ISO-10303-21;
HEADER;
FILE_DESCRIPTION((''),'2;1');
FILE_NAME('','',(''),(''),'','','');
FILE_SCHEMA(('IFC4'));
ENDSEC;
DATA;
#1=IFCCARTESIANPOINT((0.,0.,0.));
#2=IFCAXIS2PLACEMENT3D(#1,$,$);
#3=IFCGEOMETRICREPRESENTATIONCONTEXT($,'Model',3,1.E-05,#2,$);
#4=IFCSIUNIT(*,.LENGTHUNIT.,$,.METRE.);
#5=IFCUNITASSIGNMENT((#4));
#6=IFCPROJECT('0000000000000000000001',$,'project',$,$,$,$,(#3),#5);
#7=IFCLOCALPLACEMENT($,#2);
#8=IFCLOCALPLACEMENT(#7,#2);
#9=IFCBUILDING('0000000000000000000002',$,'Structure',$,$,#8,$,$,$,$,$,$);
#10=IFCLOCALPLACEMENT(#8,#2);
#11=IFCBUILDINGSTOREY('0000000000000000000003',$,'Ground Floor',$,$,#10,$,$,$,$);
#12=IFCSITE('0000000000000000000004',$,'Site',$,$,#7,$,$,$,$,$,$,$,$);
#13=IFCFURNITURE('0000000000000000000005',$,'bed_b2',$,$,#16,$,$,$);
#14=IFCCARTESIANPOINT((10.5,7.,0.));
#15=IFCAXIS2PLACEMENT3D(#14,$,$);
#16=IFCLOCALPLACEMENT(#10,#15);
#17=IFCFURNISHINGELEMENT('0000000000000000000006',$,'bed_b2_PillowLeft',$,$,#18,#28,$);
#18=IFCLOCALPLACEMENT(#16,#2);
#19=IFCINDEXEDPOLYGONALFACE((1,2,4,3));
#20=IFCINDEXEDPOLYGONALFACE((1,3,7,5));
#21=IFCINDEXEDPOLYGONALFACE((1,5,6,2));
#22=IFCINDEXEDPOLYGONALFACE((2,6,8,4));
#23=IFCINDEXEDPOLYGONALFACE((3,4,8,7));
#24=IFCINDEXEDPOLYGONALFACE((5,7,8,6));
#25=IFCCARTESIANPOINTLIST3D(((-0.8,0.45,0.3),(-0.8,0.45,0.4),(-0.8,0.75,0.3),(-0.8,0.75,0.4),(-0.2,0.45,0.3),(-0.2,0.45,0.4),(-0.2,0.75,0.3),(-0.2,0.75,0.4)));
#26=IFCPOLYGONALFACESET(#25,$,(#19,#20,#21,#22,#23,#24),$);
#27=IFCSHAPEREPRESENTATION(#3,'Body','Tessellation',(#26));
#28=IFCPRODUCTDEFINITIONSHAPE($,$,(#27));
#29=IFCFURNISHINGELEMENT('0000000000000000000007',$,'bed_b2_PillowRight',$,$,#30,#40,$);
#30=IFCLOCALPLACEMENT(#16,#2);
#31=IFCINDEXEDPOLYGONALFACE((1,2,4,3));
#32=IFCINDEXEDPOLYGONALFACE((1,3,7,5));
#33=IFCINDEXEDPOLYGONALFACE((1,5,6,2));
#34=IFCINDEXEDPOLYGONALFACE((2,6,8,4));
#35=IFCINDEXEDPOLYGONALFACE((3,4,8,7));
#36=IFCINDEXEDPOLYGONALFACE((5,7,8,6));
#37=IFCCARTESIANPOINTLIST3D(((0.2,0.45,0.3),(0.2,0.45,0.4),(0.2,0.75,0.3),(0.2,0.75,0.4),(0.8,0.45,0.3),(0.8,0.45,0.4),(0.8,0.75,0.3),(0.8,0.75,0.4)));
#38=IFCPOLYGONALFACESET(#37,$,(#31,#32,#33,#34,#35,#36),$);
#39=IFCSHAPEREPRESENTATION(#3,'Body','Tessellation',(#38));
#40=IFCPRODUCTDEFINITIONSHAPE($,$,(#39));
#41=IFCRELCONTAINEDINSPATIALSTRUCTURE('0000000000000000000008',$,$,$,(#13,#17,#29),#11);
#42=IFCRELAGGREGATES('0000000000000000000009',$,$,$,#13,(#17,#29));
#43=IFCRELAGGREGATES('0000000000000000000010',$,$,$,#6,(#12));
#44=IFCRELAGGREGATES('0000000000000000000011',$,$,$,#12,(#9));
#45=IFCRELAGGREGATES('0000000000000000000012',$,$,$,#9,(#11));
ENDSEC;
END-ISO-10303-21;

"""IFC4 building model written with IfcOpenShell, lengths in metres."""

from ifc_helpers import new_model, si_unit, frame, origin, origin_2d, place, context, project, spatial, rectangle, extrude, element, aggregate, save


model = new_model("IFC4")

# Units and contexts
model_context = context("Model", 3, precision=1e-05, world=origin())
ifc_project = project(units=[si_unit("LENGTHUNIT", "METRE")], contexts=[model_context])

# Site, building, storey
site_placement = place(None, origin())
site = spatial("IfcSite", under=ifc_project, at=site_placement, Name="Site")
building_placement = place(site_placement, origin())
building = spatial("IfcBuilding", under=site, at=building_placement, Name="Structure")
storey_placement = place(building_placement, origin())
storey = spatial("IfcBuildingStorey", under=building, at=storey_placement, Name="Ground Floor")

# Furniture, furnishing elements
furniture_1_placement = place(storey_placement, frame((10.5, 7.0, 0.0)))
furniture_1 = element("IfcFurniture", 1, at=furniture_1_placement, inside=storey, Name="bed_b2")
furnishing_1_placement = place(furniture_1_placement, origin())
furnishing_1 = element("IfcFurnishingElement", 2, at=furnishing_1_placement, inside=storey, Name="bed_b2_PillowLeft", context=model_context, shape_type="SweptSolid", body=[
    extrude(rectangle(XDim=0.6, YDim=0.3, at=origin_2d()), frame((-0.5, 0.6, 0.3)), (0.0, 0.0, 1.0), 0.1),
])
furnishing_2_placement = place(furniture_1_placement, origin())
furnishing_2 = element("IfcFurnishingElement", 3, at=furnishing_2_placement, inside=storey, Name="bed_b2_PillowRight", context=model_context, shape_type="SweptSolid", body=[
    extrude(rectangle(XDim=0.6, YDim=0.3, at=origin_2d()), frame((0.5, 0.6, 0.3)), (0.0, 0.0, 1.0), 0.1),
])
aggregate(furniture_1, [furnishing_1, furnishing_2])

save(model, "model.ifc")
